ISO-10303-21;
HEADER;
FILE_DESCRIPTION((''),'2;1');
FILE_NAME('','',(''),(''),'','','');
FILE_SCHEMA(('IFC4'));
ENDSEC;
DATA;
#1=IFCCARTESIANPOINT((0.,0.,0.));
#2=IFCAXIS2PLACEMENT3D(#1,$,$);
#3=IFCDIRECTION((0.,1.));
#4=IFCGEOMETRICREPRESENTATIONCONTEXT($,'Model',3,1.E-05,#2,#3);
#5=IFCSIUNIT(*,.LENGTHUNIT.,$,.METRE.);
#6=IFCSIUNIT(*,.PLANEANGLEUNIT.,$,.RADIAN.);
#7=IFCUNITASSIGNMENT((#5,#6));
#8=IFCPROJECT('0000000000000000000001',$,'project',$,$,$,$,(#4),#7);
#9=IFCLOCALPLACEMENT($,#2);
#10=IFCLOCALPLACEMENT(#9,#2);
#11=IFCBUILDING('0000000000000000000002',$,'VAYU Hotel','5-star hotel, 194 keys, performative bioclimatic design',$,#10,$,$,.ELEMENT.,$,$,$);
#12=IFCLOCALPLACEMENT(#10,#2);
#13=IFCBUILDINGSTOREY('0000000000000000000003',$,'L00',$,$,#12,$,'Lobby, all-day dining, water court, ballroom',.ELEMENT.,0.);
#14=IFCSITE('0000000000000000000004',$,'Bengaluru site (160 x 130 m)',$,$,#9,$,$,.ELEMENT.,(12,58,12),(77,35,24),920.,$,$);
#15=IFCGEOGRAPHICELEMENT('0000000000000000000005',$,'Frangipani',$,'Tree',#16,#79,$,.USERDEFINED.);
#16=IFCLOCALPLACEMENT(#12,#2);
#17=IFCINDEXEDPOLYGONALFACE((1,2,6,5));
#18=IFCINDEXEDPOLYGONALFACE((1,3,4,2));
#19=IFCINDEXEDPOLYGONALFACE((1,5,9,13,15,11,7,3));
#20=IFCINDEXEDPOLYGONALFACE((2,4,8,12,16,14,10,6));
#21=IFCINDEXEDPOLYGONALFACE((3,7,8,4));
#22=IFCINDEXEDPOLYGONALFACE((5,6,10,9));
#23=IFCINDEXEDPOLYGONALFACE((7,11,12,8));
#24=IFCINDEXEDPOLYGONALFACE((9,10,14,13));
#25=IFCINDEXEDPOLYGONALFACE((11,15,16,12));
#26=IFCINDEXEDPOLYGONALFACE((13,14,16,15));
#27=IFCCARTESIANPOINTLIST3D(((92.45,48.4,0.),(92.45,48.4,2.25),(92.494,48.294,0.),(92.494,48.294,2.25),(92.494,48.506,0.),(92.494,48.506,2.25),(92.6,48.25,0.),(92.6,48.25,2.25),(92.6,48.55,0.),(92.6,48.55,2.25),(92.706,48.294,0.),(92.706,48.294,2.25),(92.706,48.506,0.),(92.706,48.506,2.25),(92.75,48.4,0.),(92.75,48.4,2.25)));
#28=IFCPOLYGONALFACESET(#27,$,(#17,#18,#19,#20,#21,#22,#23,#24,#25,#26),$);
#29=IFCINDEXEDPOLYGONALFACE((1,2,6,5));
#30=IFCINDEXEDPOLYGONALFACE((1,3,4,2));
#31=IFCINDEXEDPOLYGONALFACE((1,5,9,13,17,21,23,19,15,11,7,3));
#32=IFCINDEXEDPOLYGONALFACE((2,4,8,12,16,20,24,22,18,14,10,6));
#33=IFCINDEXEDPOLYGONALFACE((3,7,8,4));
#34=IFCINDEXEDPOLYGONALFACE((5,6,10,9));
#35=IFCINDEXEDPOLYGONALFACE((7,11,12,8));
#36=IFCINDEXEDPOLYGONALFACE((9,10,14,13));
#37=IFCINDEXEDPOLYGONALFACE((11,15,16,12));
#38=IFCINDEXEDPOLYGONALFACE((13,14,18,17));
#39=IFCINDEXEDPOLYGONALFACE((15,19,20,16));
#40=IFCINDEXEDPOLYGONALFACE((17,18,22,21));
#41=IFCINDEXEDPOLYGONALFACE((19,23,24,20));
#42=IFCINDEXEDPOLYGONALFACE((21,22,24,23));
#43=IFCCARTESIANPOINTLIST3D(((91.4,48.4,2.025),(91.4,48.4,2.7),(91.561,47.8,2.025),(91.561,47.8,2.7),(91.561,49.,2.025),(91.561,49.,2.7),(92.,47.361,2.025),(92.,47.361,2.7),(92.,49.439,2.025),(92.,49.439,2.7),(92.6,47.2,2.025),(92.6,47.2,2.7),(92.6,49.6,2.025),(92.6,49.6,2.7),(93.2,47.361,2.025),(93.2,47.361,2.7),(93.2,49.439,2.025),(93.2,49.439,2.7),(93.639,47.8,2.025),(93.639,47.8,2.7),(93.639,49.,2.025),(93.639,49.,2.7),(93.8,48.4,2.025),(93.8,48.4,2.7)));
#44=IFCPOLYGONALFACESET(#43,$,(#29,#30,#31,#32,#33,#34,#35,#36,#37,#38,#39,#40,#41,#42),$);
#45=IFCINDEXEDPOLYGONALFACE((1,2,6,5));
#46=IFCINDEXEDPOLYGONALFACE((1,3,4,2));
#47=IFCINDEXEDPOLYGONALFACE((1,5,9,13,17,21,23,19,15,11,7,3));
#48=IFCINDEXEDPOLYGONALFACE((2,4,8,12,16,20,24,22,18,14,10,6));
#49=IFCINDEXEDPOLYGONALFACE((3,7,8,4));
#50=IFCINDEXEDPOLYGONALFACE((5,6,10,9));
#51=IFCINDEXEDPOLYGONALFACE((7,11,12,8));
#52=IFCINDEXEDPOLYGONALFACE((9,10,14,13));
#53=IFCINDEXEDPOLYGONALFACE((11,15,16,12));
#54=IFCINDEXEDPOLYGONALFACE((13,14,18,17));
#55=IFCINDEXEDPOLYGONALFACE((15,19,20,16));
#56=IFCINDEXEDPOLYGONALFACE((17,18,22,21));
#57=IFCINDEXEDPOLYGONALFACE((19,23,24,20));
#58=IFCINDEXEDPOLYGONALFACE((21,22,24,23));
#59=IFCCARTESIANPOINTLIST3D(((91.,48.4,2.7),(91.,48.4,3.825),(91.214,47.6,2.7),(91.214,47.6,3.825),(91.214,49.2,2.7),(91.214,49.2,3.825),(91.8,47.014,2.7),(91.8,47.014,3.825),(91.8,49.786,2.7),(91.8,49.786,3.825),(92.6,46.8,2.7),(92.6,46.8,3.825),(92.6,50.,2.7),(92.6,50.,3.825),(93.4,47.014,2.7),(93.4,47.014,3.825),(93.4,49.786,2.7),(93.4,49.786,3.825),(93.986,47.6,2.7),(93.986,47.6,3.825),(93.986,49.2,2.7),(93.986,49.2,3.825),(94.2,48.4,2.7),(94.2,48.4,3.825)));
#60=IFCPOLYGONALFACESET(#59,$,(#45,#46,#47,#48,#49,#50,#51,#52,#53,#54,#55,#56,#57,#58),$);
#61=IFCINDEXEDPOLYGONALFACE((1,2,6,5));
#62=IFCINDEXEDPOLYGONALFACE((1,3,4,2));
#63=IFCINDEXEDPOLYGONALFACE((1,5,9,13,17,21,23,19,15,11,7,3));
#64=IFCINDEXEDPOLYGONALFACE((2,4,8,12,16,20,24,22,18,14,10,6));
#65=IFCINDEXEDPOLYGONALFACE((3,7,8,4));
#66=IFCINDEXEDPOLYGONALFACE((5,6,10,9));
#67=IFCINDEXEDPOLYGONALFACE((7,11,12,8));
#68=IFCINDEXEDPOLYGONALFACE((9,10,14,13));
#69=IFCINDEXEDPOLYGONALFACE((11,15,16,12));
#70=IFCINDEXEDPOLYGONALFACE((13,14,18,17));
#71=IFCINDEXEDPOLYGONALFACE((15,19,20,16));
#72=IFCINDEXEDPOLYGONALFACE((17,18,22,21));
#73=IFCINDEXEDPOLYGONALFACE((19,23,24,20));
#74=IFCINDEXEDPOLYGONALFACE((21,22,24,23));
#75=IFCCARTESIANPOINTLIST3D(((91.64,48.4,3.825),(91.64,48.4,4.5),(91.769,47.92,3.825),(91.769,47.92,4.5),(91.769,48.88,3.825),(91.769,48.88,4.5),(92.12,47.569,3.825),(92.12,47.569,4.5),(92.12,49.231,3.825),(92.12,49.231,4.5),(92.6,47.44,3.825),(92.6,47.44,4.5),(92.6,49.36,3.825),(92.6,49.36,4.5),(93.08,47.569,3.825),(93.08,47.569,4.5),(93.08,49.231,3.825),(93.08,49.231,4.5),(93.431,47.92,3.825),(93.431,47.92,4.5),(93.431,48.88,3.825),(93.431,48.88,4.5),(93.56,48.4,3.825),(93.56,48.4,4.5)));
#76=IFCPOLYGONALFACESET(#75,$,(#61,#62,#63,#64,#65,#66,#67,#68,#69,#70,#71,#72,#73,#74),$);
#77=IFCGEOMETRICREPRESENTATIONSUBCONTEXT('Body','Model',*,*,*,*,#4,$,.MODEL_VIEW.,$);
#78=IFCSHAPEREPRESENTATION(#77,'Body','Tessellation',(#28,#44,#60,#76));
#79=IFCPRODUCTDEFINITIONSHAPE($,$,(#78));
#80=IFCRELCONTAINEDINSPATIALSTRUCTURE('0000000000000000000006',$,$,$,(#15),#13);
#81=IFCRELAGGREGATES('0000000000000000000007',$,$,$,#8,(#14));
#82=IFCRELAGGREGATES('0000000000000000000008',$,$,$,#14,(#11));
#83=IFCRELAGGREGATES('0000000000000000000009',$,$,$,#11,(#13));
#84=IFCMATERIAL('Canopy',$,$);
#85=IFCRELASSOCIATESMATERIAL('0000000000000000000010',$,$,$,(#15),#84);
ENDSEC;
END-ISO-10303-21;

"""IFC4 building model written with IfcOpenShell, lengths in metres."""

from ifc_helpers import new_model, si_unit, direction, frame, origin, place, context, subcontext, project, spatial, polyline, outline, extrude, material, element, save


model = new_model("IFC4")

# Units and contexts
model_context = context("Model", 3, precision=1e-05, world=origin(), true_north=direction((0.0, 1.0)))
body_context = subcontext(model_context, "Body", "Model", "MODEL_VIEW")
ifc_project = project(units=[si_unit("LENGTHUNIT", "METRE"), si_unit("PLANEANGLEUNIT", "RADIAN")], contexts=[model_context])

# Site, building, storey
site_placement = place(None, origin())
site = spatial("IfcSite", under=ifc_project, at=site_placement, Name="Bengaluru site (160 x 130 m)", CompositionType="ELEMENT", RefLatitude=(12, 58, 12), RefLongitude=(77, 35, 24), RefElevation=920.0)
building_placement = place(site_placement, origin())
building = spatial("IfcBuilding", under=site, at=building_placement, Name="VAYU Hotel", Description="5-star hotel, 194 keys, performative bioclimatic design", CompositionType="ELEMENT")
storey_placement = place(building_placement, origin())
storey = spatial("IfcBuildingStorey", under=building, at=storey_placement, Name="L00", LongName="Lobby, all-day dining, water court, ballroom", CompositionType="ELEMENT", Elevation=0.0)

# Geographic element
ifc_material_1 = material(Name="Canopy")
geographic_element_1_placement = place(storey_placement, origin())
element("IfcGeographicElement", 1, at=geographic_element_1_placement, inside=storey, material=ifc_material_1, Name="Frangipani", ObjectType="Tree", PredefinedType="USERDEFINED", context=body_context, shape_type="SweptSolid", body=[
    extrude(outline(polyline([(92.75, 48.4), (92.706, 48.506), (92.6, 48.55), (92.494, 48.506), (92.45, 48.4), (92.494, 48.294), (92.6, 48.25), (92.706, 48.294), (92.75, 48.4)])), origin(), (0.0, 0.0, 1.0), 2.25),
    extrude(outline(polyline([(93.8, 48.4), (93.639, 49.0), (93.2, 49.439), (92.6, 49.6), (92.0, 49.439), (91.561, 49.0), (91.4, 48.4), (91.561, 47.8), (92.0, 47.361), (92.6, 47.2), (93.2, 47.361), (93.639, 47.8), (93.8, 48.4)])), frame((0.0, 0.0, 2.025)), (0.0, 0.0, 1.0), 0.675),
    extrude(outline(polyline([(94.2, 48.4), (93.986, 49.2), (93.4, 49.786), (92.6, 50.0), (91.8, 49.786), (91.214, 49.2), (91.0, 48.4), (91.214, 47.6), (91.8, 47.014), (92.6, 46.8), (93.4, 47.014), (93.986, 47.6), (94.2, 48.4)])), frame((0.0, 0.0, 2.7)), (0.0, 0.0, 1.0), 1.125),
    extrude(outline(polyline([(93.56, 48.4), (93.431, 48.88), (93.08, 49.231), (92.6, 49.36), (92.12, 49.231), (91.769, 48.88), (91.64, 48.4), (91.769, 47.92), (92.12, 47.569), (92.6, 47.44), (93.08, 47.569), (93.431, 47.92), (93.56, 48.4)])), frame((0.0, 0.0, 3.825)), (0.0, 0.0, 1.0), 0.675),
])

save(model, "model.ifc")
